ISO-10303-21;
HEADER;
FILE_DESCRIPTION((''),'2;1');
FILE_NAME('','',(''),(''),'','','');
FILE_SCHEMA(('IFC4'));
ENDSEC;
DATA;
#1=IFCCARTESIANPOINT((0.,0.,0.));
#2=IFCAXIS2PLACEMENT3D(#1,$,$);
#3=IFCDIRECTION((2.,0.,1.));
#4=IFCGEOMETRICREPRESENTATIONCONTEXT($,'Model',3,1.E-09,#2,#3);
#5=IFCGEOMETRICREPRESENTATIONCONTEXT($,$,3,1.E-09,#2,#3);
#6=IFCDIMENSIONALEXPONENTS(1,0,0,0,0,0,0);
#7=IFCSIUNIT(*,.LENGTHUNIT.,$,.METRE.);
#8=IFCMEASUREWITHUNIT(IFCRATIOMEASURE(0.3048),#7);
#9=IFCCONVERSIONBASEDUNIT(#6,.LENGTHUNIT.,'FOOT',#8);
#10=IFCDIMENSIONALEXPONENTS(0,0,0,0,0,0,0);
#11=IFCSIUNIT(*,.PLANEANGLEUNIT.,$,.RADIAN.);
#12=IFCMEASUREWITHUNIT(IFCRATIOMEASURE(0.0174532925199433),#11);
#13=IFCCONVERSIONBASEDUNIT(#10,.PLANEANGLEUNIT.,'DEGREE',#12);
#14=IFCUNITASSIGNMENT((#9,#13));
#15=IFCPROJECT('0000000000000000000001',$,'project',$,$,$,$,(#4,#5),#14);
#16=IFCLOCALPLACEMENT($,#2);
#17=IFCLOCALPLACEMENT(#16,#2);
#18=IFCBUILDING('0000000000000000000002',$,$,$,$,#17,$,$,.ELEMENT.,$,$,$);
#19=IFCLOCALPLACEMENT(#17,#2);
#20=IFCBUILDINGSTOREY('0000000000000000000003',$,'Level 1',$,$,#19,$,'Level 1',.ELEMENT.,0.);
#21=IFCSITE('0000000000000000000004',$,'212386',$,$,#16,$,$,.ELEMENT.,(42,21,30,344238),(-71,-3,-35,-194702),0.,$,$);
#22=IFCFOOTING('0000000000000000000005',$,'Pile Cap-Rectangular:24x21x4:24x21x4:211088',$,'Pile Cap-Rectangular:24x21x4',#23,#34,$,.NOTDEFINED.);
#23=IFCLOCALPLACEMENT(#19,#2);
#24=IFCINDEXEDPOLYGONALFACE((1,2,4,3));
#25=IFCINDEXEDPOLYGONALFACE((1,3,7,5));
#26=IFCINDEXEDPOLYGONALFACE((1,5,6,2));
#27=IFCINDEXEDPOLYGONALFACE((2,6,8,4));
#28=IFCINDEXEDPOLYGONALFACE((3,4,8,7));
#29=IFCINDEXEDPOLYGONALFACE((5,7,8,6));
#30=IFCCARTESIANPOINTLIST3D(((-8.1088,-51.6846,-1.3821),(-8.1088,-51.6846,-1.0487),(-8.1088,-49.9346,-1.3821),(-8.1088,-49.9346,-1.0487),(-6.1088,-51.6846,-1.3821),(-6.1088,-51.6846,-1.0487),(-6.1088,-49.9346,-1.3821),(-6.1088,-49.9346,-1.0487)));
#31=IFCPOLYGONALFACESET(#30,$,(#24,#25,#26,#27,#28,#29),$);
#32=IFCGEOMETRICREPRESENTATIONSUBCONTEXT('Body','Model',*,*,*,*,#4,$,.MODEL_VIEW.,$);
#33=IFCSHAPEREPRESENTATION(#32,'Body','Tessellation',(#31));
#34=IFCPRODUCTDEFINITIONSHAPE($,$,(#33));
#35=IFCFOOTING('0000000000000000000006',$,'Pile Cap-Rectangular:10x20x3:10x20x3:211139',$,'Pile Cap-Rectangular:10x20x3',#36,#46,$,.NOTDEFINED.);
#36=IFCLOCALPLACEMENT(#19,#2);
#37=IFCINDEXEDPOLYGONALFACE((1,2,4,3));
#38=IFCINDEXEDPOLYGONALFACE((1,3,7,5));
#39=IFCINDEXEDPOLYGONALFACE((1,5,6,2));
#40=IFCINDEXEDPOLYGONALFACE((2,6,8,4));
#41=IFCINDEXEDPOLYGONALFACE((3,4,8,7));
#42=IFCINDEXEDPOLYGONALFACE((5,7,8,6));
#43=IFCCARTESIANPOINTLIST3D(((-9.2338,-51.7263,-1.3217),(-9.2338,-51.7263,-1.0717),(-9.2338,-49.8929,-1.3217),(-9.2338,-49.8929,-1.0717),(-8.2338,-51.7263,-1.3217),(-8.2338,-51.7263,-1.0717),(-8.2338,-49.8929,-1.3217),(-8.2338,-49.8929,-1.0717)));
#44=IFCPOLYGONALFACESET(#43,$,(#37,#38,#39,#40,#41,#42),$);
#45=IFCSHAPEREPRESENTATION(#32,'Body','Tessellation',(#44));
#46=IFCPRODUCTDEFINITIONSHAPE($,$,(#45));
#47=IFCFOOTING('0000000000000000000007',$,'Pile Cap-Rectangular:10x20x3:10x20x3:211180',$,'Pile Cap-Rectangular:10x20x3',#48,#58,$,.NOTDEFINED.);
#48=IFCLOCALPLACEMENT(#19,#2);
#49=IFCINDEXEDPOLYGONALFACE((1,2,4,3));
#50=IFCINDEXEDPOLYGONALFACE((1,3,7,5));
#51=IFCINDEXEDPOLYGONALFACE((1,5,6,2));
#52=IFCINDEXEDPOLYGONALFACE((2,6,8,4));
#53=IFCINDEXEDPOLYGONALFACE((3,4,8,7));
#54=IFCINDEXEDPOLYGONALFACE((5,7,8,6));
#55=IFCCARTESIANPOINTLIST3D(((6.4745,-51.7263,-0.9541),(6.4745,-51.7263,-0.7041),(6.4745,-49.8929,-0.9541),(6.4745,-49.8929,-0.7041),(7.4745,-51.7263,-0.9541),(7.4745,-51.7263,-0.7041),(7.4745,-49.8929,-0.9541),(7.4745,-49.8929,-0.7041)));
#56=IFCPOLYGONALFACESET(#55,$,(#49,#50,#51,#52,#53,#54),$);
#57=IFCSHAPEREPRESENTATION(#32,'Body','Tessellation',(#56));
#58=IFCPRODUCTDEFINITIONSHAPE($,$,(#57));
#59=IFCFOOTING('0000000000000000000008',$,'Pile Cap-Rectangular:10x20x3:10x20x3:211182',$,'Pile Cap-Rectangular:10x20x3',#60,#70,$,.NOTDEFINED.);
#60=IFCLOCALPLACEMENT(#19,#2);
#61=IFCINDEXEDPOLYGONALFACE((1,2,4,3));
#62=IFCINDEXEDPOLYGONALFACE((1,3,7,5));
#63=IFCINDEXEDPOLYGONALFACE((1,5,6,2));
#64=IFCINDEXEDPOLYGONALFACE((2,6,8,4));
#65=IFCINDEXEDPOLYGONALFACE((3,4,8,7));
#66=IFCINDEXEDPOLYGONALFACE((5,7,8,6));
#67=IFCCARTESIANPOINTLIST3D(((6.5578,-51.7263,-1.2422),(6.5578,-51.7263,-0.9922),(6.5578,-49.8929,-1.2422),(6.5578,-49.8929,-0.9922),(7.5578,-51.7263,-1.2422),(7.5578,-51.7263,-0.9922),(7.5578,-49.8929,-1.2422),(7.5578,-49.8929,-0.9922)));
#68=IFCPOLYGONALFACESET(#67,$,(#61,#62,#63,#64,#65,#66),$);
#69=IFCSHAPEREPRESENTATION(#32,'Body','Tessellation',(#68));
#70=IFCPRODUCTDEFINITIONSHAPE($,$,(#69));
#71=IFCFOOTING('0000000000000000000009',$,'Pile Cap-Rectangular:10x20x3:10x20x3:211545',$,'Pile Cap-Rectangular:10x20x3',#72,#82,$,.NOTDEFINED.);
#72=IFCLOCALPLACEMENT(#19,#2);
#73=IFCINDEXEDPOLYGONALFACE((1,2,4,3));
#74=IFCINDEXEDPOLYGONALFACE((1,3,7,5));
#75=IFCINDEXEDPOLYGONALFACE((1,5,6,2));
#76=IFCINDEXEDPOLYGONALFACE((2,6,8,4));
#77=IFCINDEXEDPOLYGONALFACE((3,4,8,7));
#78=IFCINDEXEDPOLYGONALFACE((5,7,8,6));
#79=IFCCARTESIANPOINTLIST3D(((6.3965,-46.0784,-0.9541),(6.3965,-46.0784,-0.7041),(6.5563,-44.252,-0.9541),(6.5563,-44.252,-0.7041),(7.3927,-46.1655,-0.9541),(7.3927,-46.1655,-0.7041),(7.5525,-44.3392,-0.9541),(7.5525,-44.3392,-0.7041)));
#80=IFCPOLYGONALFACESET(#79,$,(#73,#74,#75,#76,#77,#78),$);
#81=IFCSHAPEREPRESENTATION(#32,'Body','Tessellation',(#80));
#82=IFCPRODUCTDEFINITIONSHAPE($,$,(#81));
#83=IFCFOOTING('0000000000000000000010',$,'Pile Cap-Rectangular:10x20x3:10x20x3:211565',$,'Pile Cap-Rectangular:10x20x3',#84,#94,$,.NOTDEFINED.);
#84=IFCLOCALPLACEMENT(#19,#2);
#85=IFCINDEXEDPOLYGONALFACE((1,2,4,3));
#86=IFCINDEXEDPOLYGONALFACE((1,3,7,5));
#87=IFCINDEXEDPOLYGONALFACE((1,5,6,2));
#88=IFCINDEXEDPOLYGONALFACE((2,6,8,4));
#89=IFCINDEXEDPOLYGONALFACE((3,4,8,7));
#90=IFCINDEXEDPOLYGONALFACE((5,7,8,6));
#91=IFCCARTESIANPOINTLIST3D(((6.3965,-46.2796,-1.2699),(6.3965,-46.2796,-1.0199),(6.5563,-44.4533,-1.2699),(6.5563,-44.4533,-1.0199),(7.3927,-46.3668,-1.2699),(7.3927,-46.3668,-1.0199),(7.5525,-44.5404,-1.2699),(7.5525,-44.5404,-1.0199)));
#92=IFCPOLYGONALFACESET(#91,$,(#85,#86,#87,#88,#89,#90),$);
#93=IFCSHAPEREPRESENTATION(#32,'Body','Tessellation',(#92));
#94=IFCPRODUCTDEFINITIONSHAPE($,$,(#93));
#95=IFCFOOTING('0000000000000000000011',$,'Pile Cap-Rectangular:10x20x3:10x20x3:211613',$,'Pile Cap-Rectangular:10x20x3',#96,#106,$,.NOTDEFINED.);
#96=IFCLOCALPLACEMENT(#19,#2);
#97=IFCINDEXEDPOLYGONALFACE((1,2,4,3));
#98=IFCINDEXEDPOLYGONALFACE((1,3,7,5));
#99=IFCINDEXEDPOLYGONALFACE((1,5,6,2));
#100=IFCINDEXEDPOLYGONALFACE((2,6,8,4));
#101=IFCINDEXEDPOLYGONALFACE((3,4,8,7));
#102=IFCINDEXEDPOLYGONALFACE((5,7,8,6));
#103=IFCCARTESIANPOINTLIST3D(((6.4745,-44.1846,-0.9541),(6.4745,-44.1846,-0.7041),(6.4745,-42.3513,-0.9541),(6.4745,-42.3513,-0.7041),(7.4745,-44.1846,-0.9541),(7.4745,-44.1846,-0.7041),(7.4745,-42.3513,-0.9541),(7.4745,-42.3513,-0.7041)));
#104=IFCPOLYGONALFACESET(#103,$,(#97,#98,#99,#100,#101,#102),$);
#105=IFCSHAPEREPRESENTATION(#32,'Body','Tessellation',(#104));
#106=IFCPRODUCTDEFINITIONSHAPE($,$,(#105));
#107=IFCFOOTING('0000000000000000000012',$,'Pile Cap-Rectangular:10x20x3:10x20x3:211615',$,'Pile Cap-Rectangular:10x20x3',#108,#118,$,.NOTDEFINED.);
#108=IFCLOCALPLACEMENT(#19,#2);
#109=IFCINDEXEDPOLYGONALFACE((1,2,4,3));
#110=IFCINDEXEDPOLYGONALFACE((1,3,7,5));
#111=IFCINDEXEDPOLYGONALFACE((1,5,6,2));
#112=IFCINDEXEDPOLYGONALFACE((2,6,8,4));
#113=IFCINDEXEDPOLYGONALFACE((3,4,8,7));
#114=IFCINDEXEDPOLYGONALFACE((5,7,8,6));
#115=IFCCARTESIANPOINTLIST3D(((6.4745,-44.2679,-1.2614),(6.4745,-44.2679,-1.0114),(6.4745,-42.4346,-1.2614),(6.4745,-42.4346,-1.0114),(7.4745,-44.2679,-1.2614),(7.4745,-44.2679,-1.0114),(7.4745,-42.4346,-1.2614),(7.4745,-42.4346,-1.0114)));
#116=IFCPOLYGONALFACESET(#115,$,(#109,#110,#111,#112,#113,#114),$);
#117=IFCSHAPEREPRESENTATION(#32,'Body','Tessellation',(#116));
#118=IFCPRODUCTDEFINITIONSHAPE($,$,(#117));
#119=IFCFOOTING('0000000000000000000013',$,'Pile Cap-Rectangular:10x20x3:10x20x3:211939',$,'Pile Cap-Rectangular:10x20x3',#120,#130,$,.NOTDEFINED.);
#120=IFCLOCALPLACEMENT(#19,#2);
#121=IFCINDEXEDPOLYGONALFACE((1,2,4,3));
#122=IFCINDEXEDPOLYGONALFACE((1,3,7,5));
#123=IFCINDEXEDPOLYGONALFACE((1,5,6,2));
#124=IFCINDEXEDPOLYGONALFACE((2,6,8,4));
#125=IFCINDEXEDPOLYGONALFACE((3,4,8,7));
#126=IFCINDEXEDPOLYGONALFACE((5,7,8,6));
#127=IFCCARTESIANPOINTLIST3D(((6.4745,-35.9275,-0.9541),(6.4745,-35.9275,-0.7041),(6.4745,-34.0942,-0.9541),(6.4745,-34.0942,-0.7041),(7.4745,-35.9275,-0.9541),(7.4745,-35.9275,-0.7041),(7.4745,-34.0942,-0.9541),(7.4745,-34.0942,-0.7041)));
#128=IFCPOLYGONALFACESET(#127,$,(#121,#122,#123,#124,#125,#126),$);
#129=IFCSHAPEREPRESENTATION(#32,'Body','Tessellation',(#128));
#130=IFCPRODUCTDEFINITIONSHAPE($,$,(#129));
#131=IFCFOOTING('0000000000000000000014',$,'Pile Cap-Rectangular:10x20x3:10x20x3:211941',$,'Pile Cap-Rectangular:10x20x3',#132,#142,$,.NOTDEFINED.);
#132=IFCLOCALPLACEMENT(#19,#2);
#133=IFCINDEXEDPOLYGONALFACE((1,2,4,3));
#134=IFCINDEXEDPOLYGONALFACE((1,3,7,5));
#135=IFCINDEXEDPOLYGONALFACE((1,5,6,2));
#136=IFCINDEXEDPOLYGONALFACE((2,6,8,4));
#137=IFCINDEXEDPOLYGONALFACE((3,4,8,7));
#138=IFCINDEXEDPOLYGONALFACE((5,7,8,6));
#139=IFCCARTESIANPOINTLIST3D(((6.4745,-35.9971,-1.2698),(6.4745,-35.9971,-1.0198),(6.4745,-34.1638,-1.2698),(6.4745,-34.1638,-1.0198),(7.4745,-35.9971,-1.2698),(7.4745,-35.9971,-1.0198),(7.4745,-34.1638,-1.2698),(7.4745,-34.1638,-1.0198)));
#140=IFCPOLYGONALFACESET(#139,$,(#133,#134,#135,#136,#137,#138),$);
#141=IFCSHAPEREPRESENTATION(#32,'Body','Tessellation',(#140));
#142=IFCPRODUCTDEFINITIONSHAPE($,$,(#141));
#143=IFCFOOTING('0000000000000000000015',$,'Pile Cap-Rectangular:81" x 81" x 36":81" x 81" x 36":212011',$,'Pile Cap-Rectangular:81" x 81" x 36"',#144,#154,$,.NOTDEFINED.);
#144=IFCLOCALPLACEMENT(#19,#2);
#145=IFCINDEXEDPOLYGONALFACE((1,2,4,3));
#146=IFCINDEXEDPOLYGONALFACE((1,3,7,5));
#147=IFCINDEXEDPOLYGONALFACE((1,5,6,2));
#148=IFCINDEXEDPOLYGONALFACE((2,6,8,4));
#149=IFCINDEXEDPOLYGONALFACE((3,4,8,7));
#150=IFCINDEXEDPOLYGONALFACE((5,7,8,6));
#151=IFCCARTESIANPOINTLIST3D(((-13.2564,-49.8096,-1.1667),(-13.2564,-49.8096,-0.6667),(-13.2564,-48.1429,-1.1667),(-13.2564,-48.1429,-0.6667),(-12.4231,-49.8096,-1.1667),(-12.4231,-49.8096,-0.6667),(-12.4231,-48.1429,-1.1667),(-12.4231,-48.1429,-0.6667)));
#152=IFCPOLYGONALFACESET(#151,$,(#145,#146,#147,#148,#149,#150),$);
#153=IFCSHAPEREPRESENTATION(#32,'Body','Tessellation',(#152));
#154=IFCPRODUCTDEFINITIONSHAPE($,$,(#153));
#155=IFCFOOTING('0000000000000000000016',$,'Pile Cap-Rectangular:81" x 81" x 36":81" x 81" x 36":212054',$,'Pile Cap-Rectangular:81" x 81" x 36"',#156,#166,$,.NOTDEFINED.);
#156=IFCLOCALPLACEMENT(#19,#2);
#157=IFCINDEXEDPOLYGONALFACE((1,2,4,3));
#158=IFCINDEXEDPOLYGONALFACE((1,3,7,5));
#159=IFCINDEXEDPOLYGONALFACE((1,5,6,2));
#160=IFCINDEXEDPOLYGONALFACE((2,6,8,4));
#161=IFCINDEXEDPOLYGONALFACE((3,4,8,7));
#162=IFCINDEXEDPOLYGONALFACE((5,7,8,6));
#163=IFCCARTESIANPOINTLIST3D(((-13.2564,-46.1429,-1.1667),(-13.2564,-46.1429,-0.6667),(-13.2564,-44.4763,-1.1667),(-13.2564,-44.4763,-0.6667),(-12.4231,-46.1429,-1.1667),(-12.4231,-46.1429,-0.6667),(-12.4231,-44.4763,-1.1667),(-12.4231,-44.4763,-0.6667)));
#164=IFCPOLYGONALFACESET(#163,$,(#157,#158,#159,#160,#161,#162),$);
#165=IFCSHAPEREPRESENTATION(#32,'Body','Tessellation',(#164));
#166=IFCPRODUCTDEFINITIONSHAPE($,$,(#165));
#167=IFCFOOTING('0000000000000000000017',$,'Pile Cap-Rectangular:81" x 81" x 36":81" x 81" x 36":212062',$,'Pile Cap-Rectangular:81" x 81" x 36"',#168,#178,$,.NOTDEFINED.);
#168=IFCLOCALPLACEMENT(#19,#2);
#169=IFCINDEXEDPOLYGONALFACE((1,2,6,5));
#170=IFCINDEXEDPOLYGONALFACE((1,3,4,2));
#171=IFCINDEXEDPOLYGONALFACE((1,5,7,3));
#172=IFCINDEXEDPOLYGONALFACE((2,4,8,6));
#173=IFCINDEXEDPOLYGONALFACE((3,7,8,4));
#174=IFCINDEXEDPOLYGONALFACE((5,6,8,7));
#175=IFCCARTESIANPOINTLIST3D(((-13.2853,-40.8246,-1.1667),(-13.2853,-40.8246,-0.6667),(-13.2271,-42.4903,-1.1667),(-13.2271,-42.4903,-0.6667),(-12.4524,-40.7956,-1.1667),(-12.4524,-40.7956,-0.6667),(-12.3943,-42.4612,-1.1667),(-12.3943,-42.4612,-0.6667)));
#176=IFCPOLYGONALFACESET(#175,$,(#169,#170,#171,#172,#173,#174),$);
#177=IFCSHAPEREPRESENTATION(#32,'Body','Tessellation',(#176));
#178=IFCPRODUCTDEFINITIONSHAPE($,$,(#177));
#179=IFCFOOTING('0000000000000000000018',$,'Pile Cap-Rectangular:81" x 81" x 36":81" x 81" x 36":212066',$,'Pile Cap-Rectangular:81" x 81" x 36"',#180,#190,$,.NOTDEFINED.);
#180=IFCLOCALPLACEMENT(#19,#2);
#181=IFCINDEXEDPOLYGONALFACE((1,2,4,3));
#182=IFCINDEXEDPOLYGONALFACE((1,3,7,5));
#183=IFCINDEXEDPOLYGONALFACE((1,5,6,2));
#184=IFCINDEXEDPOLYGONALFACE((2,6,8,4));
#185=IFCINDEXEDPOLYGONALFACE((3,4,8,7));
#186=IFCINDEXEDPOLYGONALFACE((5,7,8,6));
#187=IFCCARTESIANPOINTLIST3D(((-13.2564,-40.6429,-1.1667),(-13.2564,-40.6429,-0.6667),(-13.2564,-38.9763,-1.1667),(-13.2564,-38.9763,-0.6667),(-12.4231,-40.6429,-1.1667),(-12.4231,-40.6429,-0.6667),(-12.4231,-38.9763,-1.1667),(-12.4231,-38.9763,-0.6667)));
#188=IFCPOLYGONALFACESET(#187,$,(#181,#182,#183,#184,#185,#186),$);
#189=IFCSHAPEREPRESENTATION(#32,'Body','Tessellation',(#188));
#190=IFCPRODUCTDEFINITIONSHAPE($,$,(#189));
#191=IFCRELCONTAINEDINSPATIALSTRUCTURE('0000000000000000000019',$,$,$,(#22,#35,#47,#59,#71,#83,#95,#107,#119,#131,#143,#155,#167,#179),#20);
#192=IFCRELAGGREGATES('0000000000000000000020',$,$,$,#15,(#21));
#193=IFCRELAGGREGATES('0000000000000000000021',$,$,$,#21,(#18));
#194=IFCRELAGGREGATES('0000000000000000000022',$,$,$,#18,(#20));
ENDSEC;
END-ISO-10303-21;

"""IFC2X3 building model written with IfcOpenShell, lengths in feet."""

from ifc_helpers import new_model, entity, si_unit, converted_unit, direction, frame, frame_2d, origin, origin_2d_with_axis, place, context, subcontext, project, spatial, rectangle, extrude, element, save


model = new_model("IFC2X3")

# Units and contexts
model_context = context("Model", 3, precision=1e-09, world=origin(), true_north=direction((2.0, 0.0, 1.0)))
context_of_model = context(None, 3, precision=1e-09, world=origin(), true_north=direction((2.0, 0.0, 1.0)))
body_context = subcontext(model_context, "Body", "Model", "MODEL_VIEW")
ifc_project = project(units=[converted_unit("LENGTHUNIT", "FOOT", entity("IfcRatioMeasure", 0.3048), si_unit("LENGTHUNIT", "METRE"), dimensions=[1, 0, 0, 0, 0, 0, 0]), converted_unit("PLANEANGLEUNIT", "DEGREE", entity("IfcRatioMeasure", 0.0174532925199433), si_unit("PLANEANGLEUNIT", "RADIAN"), dimensions=[0, 0, 0, 0, 0, 0, 0])], contexts=[model_context, context_of_model])

# Site, building, storey
site_placement = place(None, origin())
site = spatial("IfcSite", under=ifc_project, at=site_placement, Name="212386", CompositionType="ELEMENT", RefLatitude=(42, 21, 30, 344238), RefLongitude=(-71, -3, -35, -194702), RefElevation=0.0)
building_placement = place(site_placement, origin())
building = spatial("IfcBuilding", under=site, at=building_placement, CompositionType="ELEMENT")
storey_placement = place(building_placement, origin())
storey = spatial("IfcBuildingStorey", under=building, at=storey_placement, Name="Level 1", LongName="Level 1", CompositionType="ELEMENT", Elevation=0.0)

# Footings
footing_1_placement = place(storey_placement, origin())
element("IfcFooting", 1, at=footing_1_placement, inside=storey, Name="Pile Cap-Rectangular:24x21x4:24x21x4:211088", ObjectType="Pile Cap-Rectangular:24x21x4", PredefinedType="NOTDEFINED", context=body_context, shape_type="SweptSolid", body=[
    extrude(rectangle(XDim=2.0, YDim=1.75, at=origin_2d_with_axis()), frame((-7.1088, -50.8096, -1.3821), z_axis=(0.0, 0.0, 1.0), x_axis=(-1.0, 0.0, 0.0)), (0.0, 0.0, 1.0), 0.3333),
])
footing_2_placement = place(storey_placement, origin())
element("IfcFooting", 2, at=footing_2_placement, inside=storey, Name="Pile Cap-Rectangular:10x20x3:10x20x3:211139", ObjectType="Pile Cap-Rectangular:10x20x3", PredefinedType="NOTDEFINED", context=body_context, shape_type="SweptSolid", body=[
    extrude(rectangle(XDim=1.0, YDim=1.8333, at=frame_2d((0.0, 0.0), x_axis=(1.0, 0.0))), frame((-8.7338, -50.8096, -1.3217), z_axis=(0.0, 0.0, 1.0), x_axis=(-1.0, 0.0, 0.0)), (0.0, 0.0, 1.0), 0.25),
])
footing_3_placement = place(storey_placement, origin())
element("IfcFooting", 3, at=footing_3_placement, inside=storey, Name="Pile Cap-Rectangular:10x20x3:10x20x3:211180", ObjectType="Pile Cap-Rectangular:10x20x3", PredefinedType="NOTDEFINED", context=body_context, shape_type="SweptSolid", body=[
    extrude(rectangle(XDim=1.0, YDim=1.8333, at=frame_2d((0.0, 0.0), x_axis=(1.0, 0.0))), frame((6.9745, -50.8096, -0.9541), z_axis=(0.0, 0.0, 1.0), x_axis=(-1.0, 0.0, 0.0)), (0.0, 0.0, 1.0), 0.25),
])
footing_4_placement = place(storey_placement, origin())
element("IfcFooting", 4, at=footing_4_placement, inside=storey, Name="Pile Cap-Rectangular:10x20x3:10x20x3:211182", ObjectType="Pile Cap-Rectangular:10x20x3", PredefinedType="NOTDEFINED", context=body_context, shape_type="SweptSolid", body=[
    extrude(rectangle(XDim=1.0, YDim=1.8333, at=frame_2d((0.0, 0.0), x_axis=(1.0, 0.0))), frame((7.0578, -50.8096, -1.2422), z_axis=(0.0, 0.0, 1.0), x_axis=(-1.0, 0.0, 0.0)), (0.0, 0.0, 1.0), 0.25),
])
footing_5_placement = place(storey_placement, origin())
element("IfcFooting", 5, at=footing_5_placement, inside=storey, Name="Pile Cap-Rectangular:10x20x3:10x20x3:211545", ObjectType="Pile Cap-Rectangular:10x20x3", PredefinedType="NOTDEFINED", context=body_context, shape_type="SweptSolid", body=[
    extrude(rectangle(XDim=1.0, YDim=1.8333, at=frame_2d((0.0, 0.0), x_axis=(1.0, 0.0))), frame((6.9745, -45.2088, -0.9541), z_axis=(0.0, 0.0, 1.0), x_axis=(-0.996195, 0.087156, 0.0)), (0.0, 0.0, 1.0), 0.25),
])
footing_6_placement = place(storey_placement, origin())
element("IfcFooting", 6, at=footing_6_placement, inside=storey, Name="Pile Cap-Rectangular:10x20x3:10x20x3:211565", ObjectType="Pile Cap-Rectangular:10x20x3", PredefinedType="NOTDEFINED", context=body_context, shape_type="SweptSolid", body=[
    extrude(rectangle(XDim=1.0, YDim=1.8333, at=frame_2d((0.0, 0.0), x_axis=(1.0, 0.0))), frame((6.9745, -45.41, -1.2699), z_axis=(0.0, 0.0, 1.0), x_axis=(-0.996195, 0.087156, 0.0)), (0.0, 0.0, 1.0), 0.25),
])
footing_7_placement = place(storey_placement, origin())
element("IfcFooting", 7, at=footing_7_placement, inside=storey, Name="Pile Cap-Rectangular:10x20x3:10x20x3:211613", ObjectType="Pile Cap-Rectangular:10x20x3", PredefinedType="NOTDEFINED", context=body_context, shape_type="SweptSolid", body=[
    extrude(rectangle(XDim=1.0, YDim=1.8333, at=frame_2d((0.0, 0.0), x_axis=(1.0, 0.0))), frame((6.9745, -43.2679, -0.9541), z_axis=(0.0, 0.0, 1.0), x_axis=(-1.0, 0.0, 0.0)), (0.0, 0.0, 1.0), 0.25),
])
footing_8_placement = place(storey_placement, origin())
element("IfcFooting", 8, at=footing_8_placement, inside=storey, Name="Pile Cap-Rectangular:10x20x3:10x20x3:211615", ObjectType="Pile Cap-Rectangular:10x20x3", PredefinedType="NOTDEFINED", context=body_context, shape_type="SweptSolid", body=[
    extrude(rectangle(XDim=1.0, YDim=1.8333, at=frame_2d((0.0, 0.0), x_axis=(1.0, 0.0))), frame((6.9745, -43.3513, -1.2614), z_axis=(0.0, 0.0, 1.0), x_axis=(-1.0, 0.0, 0.0)), (0.0, 0.0, 1.0), 0.25),
])
footing_9_placement = place(storey_placement, origin())
element("IfcFooting", 9, at=footing_9_placement, inside=storey, Name="Pile Cap-Rectangular:10x20x3:10x20x3:211939", ObjectType="Pile Cap-Rectangular:10x20x3", PredefinedType="NOTDEFINED", context=body_context, shape_type="SweptSolid", body=[
    extrude(rectangle(XDim=1.0, YDim=1.8333, at=frame_2d((0.0, 0.0), x_axis=(1.0, 0.0))), frame((6.9745, -35.0108, -0.9541), z_axis=(0.0, 0.0, 1.0), x_axis=(-1.0, 0.0, 0.0)), (0.0, 0.0, 1.0), 0.25),
])
footing_10_placement = place(storey_placement, origin())
element("IfcFooting", 10, at=footing_10_placement, inside=storey, Name="Pile Cap-Rectangular:10x20x3:10x20x3:211941", ObjectType="Pile Cap-Rectangular:10x20x3", PredefinedType="NOTDEFINED", context=body_context, shape_type="SweptSolid", body=[
    extrude(rectangle(XDim=1.0, YDim=1.8333, at=frame_2d((0.0, 0.0), x_axis=(1.0, 0.0))), frame((6.9745, -35.0804, -1.2698), z_axis=(0.0, 0.0, 1.0), x_axis=(-1.0, 0.0, 0.0)), (0.0, 0.0, 1.0), 0.25),
])
footing_11_placement = place(storey_placement, origin())
element("IfcFooting", 11, at=footing_11_placement, inside=storey, Name="Pile Cap-Rectangular:81\" x 81\" x 36\":81\" x 81\" x 36\":212011", ObjectType="Pile Cap-Rectangular:81\" x 81\" x 36\"", PredefinedType="NOTDEFINED", context=body_context, shape_type="SweptSolid", body=[
    extrude(rectangle(XDim=0.8333, YDim=1.6667, at=frame_2d((0.0, 0.0), x_axis=(1.0, 0.0))), frame((-12.8398, -48.9763, -1.1667), z_axis=(0.0, 0.0, 1.0), x_axis=(-1.0, 0.0, 0.0)), (0.0, 0.0, 1.0), 0.5),
])
footing_12_placement = place(storey_placement, origin())
element("IfcFooting", 12, at=footing_12_placement, inside=storey, Name="Pile Cap-Rectangular:81\" x 81\" x 36\":81\" x 81\" x 36\":212054", ObjectType="Pile Cap-Rectangular:81\" x 81\" x 36\"", PredefinedType="NOTDEFINED", context=body_context, shape_type="SweptSolid", body=[
    extrude(rectangle(XDim=0.8333, YDim=1.6667, at=frame_2d((0.0, 0.0), x_axis=(1.0, 0.0))), frame((-12.8398, -45.3096, -1.1667), z_axis=(0.0, 0.0, 1.0), x_axis=(-1.0, 0.0, 0.0)), (0.0, 0.0, 1.0), 0.5),
])
footing_13_placement = place(storey_placement, origin())
element("IfcFooting", 13, at=footing_13_placement, inside=storey, Name="Pile Cap-Rectangular:81\" x 81\" x 36\":81\" x 81\" x 36\":212062", ObjectType="Pile Cap-Rectangular:81\" x 81\" x 36\"", PredefinedType="NOTDEFINED", context=body_context, shape_type="SweptSolid", body=[
    extrude(rectangle(XDim=0.8333, YDim=1.6667, at=frame_2d((0.0, 0.0), x_axis=(1.0, 0.0))), frame((-12.8398, -41.6429, -1.1667), z_axis=(0.0, 0.0, 1.0), x_axis=(-0.999391, -0.034899, 0.0)), (0.0, 0.0, 1.0), 0.5),
])
footing_14_placement = place(storey_placement, origin())
element("IfcFooting", 14, at=footing_14_placement, inside=storey, Name="Pile Cap-Rectangular:81\" x 81\" x 36\":81\" x 81\" x 36\":212066", ObjectType="Pile Cap-Rectangular:81\" x 81\" x 36\"", PredefinedType="NOTDEFINED", context=body_context, shape_type="SweptSolid", body=[
    extrude(rectangle(XDim=0.8333, YDim=1.6667, at=frame_2d((0.0, 0.0), x_axis=(1.0, 0.0))), frame((-12.8398, -39.8096, -1.1667), z_axis=(0.0, 0.0, 1.0), x_axis=(-1.0, 0.0, 0.0)), (0.0, 0.0, 1.0), 0.5),
])

save(model, "model.ifc")
